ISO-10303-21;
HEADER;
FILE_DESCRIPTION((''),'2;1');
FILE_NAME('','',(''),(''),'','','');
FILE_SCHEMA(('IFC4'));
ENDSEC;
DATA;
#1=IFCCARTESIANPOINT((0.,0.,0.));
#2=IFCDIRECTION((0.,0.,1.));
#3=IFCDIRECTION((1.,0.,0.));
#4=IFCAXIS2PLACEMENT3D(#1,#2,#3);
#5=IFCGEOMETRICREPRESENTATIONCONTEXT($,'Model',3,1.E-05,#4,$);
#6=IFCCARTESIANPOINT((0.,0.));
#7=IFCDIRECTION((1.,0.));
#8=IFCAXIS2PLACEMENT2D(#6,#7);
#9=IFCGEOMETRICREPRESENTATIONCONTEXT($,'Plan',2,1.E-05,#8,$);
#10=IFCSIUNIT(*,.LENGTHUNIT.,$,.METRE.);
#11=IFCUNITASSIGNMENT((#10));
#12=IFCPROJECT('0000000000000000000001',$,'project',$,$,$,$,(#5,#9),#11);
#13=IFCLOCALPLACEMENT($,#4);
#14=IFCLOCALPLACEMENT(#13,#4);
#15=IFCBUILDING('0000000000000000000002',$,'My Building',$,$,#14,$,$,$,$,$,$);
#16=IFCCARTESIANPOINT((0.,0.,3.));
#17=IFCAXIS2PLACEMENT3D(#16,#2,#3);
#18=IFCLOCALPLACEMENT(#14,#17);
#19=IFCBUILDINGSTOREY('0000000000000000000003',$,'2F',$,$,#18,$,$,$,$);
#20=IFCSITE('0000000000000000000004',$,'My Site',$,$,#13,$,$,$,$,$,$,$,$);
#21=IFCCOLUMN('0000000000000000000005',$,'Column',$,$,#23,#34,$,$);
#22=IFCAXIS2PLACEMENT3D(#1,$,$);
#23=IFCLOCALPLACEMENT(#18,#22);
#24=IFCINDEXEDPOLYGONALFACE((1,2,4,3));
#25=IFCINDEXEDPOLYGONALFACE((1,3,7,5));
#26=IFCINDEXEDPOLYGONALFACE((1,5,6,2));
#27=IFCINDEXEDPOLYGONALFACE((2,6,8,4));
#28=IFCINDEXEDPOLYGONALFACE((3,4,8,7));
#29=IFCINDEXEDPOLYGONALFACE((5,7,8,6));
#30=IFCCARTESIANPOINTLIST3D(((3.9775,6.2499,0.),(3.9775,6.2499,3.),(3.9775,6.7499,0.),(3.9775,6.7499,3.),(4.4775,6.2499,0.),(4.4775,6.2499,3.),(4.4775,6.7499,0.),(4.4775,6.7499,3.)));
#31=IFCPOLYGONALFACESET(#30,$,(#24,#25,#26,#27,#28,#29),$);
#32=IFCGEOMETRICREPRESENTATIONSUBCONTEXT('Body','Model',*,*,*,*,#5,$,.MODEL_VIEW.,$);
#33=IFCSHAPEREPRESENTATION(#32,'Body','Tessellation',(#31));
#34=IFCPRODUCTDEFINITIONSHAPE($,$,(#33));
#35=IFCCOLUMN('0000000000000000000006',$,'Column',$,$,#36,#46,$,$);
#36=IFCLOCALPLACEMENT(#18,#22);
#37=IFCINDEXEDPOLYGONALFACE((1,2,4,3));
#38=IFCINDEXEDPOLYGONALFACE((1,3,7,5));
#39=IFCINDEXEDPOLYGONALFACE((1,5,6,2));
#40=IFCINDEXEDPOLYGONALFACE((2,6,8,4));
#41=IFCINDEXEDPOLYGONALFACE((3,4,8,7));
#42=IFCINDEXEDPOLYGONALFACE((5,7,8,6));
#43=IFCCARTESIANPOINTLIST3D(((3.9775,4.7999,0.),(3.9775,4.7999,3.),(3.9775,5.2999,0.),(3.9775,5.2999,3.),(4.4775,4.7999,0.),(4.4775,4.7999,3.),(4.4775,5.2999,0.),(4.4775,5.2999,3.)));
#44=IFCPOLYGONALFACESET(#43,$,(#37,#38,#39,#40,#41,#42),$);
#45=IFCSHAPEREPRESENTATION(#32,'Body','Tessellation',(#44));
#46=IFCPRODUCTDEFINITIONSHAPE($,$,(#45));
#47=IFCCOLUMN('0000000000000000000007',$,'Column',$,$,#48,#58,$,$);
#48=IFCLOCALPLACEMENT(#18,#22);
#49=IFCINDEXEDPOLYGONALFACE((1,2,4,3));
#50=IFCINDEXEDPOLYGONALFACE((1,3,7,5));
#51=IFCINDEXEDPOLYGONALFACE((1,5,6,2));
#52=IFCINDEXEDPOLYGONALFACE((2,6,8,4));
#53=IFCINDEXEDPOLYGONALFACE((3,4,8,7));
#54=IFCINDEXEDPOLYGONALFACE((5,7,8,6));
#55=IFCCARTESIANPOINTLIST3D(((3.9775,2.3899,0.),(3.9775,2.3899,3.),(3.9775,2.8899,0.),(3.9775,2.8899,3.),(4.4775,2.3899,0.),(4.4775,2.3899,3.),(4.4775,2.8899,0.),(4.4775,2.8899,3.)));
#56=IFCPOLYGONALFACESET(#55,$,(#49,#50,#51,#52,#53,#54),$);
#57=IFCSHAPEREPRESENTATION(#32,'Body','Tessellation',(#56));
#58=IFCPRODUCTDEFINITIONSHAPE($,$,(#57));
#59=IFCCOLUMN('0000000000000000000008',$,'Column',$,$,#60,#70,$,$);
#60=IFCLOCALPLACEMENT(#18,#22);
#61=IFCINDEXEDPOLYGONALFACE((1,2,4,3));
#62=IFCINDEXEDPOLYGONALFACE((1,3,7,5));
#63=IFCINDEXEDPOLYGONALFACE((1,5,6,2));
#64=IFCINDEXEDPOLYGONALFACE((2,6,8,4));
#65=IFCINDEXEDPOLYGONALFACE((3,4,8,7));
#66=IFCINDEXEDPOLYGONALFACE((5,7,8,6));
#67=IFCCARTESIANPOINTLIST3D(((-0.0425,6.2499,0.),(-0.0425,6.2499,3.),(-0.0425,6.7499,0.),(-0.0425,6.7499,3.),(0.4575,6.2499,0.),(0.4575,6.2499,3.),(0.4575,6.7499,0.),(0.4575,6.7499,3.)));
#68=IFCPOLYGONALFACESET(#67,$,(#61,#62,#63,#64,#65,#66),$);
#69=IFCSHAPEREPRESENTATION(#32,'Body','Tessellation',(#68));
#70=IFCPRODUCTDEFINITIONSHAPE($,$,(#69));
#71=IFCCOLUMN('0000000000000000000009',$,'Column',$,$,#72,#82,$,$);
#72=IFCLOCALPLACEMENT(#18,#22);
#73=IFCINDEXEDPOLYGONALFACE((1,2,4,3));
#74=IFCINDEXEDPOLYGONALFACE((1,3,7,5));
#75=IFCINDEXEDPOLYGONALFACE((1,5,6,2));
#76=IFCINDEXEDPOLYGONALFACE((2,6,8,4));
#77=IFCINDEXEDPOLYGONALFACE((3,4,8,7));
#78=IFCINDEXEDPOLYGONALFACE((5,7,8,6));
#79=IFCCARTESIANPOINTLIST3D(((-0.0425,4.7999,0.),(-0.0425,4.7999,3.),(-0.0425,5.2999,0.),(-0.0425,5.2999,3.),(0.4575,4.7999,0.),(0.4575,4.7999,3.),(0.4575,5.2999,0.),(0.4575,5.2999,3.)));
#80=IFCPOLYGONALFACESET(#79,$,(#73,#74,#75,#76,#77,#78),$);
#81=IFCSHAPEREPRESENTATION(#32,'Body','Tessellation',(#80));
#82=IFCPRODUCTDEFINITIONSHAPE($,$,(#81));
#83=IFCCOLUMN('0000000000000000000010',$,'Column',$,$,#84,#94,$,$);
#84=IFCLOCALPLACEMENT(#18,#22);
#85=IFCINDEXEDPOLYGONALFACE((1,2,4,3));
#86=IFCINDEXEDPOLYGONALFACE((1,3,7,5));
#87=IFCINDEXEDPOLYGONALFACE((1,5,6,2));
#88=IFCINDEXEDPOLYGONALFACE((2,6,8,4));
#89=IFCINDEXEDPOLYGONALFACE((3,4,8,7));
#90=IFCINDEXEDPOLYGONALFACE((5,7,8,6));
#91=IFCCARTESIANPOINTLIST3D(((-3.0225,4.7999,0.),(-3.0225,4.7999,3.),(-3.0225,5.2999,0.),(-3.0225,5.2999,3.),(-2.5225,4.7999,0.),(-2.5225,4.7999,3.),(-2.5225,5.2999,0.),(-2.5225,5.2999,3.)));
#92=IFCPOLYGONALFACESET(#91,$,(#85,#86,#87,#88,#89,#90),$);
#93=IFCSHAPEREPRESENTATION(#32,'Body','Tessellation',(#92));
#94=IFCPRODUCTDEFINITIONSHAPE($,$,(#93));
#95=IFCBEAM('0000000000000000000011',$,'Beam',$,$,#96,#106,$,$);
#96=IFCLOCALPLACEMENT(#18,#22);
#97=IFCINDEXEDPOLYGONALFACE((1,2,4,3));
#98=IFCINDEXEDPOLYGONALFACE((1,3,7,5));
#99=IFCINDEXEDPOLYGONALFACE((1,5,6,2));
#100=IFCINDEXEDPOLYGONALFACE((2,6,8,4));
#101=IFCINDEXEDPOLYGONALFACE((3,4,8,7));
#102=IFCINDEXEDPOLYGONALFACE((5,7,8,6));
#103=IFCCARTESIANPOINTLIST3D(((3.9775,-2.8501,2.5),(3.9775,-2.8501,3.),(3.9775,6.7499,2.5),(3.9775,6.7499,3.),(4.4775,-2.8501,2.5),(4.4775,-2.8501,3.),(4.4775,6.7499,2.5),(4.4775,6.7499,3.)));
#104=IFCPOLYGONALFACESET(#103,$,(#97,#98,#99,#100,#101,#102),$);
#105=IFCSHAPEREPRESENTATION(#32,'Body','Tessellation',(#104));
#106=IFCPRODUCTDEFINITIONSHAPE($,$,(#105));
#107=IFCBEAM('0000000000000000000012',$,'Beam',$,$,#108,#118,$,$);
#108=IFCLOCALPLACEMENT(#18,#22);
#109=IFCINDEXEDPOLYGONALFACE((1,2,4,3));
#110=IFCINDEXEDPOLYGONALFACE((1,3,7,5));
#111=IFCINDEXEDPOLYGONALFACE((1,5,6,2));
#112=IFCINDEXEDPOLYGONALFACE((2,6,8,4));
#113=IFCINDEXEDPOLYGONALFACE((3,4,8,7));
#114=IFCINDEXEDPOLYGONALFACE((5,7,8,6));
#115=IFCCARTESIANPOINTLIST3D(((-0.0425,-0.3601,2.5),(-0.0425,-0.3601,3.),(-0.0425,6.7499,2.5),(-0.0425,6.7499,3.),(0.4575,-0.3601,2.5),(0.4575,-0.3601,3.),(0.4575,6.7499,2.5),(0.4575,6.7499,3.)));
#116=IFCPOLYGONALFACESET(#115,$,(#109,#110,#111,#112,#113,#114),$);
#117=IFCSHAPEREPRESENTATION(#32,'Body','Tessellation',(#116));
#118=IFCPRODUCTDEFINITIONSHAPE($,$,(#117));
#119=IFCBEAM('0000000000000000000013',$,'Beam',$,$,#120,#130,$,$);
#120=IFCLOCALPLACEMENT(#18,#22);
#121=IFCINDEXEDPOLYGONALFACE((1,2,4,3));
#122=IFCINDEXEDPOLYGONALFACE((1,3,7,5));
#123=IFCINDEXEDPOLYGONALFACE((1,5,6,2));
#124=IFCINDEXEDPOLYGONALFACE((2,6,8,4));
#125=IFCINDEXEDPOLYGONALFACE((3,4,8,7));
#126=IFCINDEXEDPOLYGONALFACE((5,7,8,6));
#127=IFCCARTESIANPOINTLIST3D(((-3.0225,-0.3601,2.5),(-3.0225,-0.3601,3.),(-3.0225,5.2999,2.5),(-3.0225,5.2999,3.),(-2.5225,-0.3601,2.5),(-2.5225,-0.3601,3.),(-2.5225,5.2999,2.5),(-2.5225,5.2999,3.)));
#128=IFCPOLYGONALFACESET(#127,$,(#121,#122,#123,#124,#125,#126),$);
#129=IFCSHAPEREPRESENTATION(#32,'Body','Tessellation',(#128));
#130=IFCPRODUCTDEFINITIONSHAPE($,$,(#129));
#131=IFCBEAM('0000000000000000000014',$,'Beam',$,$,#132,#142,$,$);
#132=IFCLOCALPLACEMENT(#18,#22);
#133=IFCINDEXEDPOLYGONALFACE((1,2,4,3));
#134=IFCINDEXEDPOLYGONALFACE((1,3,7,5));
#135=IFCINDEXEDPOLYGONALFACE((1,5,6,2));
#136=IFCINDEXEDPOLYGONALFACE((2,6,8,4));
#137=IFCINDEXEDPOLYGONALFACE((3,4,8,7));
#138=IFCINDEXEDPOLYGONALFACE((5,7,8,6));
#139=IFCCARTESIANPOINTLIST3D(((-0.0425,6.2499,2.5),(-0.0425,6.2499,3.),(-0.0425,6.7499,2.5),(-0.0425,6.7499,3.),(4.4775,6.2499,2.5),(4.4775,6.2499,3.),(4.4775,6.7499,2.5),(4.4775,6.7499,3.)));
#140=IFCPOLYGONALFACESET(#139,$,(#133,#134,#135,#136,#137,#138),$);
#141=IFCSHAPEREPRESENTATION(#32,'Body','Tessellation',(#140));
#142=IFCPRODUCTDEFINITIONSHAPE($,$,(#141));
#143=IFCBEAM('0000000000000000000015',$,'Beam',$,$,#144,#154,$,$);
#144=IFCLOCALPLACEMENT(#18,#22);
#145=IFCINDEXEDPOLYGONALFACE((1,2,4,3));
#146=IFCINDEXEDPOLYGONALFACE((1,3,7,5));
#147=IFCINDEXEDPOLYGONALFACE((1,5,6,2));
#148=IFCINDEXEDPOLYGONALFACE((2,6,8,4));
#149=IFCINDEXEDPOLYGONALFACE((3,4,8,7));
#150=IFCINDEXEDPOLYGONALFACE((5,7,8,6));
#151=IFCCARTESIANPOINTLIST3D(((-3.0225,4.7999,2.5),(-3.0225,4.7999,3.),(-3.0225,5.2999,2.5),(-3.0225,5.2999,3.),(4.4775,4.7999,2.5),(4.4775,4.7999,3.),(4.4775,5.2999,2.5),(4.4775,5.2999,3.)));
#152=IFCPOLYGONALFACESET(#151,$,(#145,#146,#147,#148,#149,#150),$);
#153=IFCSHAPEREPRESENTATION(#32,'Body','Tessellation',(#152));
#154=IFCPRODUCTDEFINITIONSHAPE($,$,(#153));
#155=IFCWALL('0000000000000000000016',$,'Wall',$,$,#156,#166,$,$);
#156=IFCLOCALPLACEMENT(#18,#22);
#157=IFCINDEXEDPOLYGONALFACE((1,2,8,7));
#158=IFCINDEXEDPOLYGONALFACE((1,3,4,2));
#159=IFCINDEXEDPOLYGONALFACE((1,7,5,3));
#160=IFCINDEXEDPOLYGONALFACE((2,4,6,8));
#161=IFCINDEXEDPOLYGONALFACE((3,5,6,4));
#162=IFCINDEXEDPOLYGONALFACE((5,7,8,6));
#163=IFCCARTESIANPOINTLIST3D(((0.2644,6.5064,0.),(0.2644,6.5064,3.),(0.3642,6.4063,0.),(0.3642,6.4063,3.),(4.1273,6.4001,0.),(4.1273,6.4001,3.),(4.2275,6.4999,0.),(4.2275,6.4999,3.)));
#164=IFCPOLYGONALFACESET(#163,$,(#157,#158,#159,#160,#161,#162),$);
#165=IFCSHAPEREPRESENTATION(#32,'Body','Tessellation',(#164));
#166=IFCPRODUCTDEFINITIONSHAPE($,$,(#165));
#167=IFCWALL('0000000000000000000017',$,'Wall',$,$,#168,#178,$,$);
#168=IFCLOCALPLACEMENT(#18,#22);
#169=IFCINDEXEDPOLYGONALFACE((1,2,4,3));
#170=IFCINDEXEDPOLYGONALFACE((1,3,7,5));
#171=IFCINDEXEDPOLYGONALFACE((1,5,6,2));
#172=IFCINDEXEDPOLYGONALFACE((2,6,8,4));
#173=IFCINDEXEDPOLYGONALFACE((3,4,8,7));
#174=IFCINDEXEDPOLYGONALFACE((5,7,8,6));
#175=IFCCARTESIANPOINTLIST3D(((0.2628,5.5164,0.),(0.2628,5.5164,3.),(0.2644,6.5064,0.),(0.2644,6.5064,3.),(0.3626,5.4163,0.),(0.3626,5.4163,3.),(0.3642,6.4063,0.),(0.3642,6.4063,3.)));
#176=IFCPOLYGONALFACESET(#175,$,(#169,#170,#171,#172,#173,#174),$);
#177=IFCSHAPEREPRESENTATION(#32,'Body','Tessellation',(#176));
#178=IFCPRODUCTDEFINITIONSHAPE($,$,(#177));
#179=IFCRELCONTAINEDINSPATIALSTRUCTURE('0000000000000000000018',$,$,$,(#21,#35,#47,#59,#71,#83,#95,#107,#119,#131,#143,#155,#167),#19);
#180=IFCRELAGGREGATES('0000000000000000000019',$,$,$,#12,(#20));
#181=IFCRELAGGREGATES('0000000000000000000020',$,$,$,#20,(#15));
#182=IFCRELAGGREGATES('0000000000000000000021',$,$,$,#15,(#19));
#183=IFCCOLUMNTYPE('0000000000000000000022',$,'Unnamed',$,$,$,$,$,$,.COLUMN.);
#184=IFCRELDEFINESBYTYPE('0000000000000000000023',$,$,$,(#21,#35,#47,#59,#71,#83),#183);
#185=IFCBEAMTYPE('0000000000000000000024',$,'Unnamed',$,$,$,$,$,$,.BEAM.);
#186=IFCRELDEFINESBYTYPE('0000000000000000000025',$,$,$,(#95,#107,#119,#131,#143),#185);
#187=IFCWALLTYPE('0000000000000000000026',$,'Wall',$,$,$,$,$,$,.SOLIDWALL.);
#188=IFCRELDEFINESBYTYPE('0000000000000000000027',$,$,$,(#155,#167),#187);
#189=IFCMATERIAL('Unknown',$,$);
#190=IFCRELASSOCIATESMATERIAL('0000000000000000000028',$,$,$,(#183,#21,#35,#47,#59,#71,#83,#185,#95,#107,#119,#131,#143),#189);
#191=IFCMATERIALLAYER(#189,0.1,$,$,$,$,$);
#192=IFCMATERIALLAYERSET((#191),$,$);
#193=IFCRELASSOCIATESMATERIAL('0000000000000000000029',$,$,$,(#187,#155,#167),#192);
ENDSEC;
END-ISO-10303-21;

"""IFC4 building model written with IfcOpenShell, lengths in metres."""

from ifc_helpers import new_model, si_unit, frame, origin_with_axes, origin_2d_with_axis, place, context, subcontext, project, spatial, line, indexed_curve, rectangle, outline, extrude, material, layer, layer_set, layer_usage, material_profile, profile_set, profile_usage, type_object, element, save


model = new_model("IFC4")

# Units and contexts
model_context = context("Model", 3, precision=1e-05, world=origin_with_axes())
plan_context = context("Plan", 2, precision=1e-05, world=origin_2d_with_axis())
body_context_1 = subcontext(model_context, "Body", "Model", "MODEL_VIEW")
ifc_project = project(units=[si_unit("LENGTHUNIT", "METRE")], contexts=[model_context, plan_context])

# Site, building, storey
site_placement = place(None, origin_with_axes())
site = spatial("IfcSite", under=ifc_project, at=site_placement, Name="My Site")
building_placement = place(site_placement, origin_with_axes())
building = spatial("IfcBuilding", under=site, at=building_placement, Name="My Building")
storey_placement = place(building_placement, frame((0.0, 0.0, 3.0), z_axis=(0.0, 0.0, 1.0), x_axis=(1.0, 0.0, 0.0)))
storey = spatial("IfcBuildingStorey", under=building, at=storey_placement, Name="2F")

# Columns
ifc_material = material(Name="Unknown")
ifc_material_profile_1 = material_profile(ifc_material, rectangle(XDim=0.5, YDim=0.5))
ifc_profile_set_1 = profile_set([ifc_material_profile_1])
ifc_profile_usage_1 = profile_usage(ifc_profile_set_1, cardinal=5)
column_type = type_object("IfcColumnType", Name="Unnamed", PredefinedType="COLUMN", material=ifc_profile_set_1)
column_1_placement = place(storey_placement, frame((4.2275, 6.4999, 0.0), z_axis=(0.0, 0.0, 1.0), x_axis=(1.0, 0.0, 0.0)))
element("IfcColumn", 1, at=column_1_placement, inside=storey, type_object=column_type, material=ifc_profile_usage_1, Name="Column", context=body_context_1, shape_type="SweptSolid", body=[
    extrude(rectangle(XDim=0.5, YDim=0.5), origin_with_axes(), (0.0, 0.0, 1.0), 3.0),
])
ifc_profile_usage_2 = profile_usage(ifc_profile_set_1, cardinal=5)
column_2_placement = place(storey_placement, frame((4.2275, 5.0499, 0.0), z_axis=(0.0, 0.0, 1.0), x_axis=(1.0, 0.0, 0.0)))
element("IfcColumn", 2, at=column_2_placement, inside=storey, type_object=column_type, material=ifc_profile_usage_2, Name="Column", context=body_context_1, shape_type="SweptSolid", body=[
    extrude(rectangle(XDim=0.5, YDim=0.5), origin_with_axes(), (0.0, 0.0, 1.0), 3.0),
])
ifc_profile_usage_3 = profile_usage(ifc_profile_set_1, cardinal=5)
column_3_placement = place(storey_placement, frame((4.2275, 2.6399, 0.0), z_axis=(0.0, 0.0, 1.0), x_axis=(1.0, 0.0, 0.0)))
element("IfcColumn", 3, at=column_3_placement, inside=storey, type_object=column_type, material=ifc_profile_usage_3, Name="Column", context=body_context_1, shape_type="SweptSolid", body=[
    extrude(rectangle(XDim=0.5, YDim=0.5), origin_with_axes(), (0.0, 0.0, 1.0), 3.0),
])
ifc_profile_usage_4 = profile_usage(ifc_profile_set_1, cardinal=5)
column_4_placement = place(storey_placement, frame((0.2075, 6.4999, 0.0), z_axis=(0.0, 0.0, 1.0), x_axis=(1.0, 0.0, 0.0)))
element("IfcColumn", 4, at=column_4_placement, inside=storey, type_object=column_type, material=ifc_profile_usage_4, Name="Column", context=body_context_1, shape_type="SweptSolid", body=[
    extrude(rectangle(XDim=0.5, YDim=0.5), origin_with_axes(), (0.0, 0.0, 1.0), 3.0),
])
ifc_profile_usage_5 = profile_usage(ifc_profile_set_1, cardinal=5)
column_5_placement = place(storey_placement, frame((0.2075, 5.0499, 0.0), z_axis=(0.0, 0.0, 1.0), x_axis=(1.0, 0.0, 0.0)))
element("IfcColumn", 5, at=column_5_placement, inside=storey, type_object=column_type, material=ifc_profile_usage_5, Name="Column", context=body_context_1, shape_type="SweptSolid", body=[
    extrude(rectangle(XDim=0.5, YDim=0.5), origin_with_axes(), (0.0, 0.0, 1.0), 3.0),
])
ifc_profile_usage_6 = profile_usage(ifc_profile_set_1, cardinal=5)
column_6_placement = place(storey_placement, frame((-2.7725, 5.0499, 0.0), z_axis=(0.0, 0.0, 1.0), x_axis=(1.0, 0.0, 0.0)))
element("IfcColumn", 6, at=column_6_placement, inside=storey, type_object=column_type, material=ifc_profile_usage_6, Name="Column", context=body_context_1, shape_type="SweptSolid", body=[
    extrude(rectangle(XDim=0.5, YDim=0.5), origin_with_axes(), (0.0, 0.0, 1.0), 3.0),
])

# Beams
ifc_material_profile_2 = material_profile(ifc_material, rectangle(XDim=0.5, YDim=0.5))
ifc_profile_set_2 = profile_set([ifc_material_profile_2])
ifc_profile_usage_7 = profile_usage(ifc_profile_set_2, cardinal=7)
beam_type = type_object("IfcBeamType", Name="Unnamed", PredefinedType="BEAM", material=ifc_profile_set_2)
beam_1_placement = place(storey_placement, frame((4.4775, 6.7499, 3.0), z_axis=(0.0, -1.0, 0.0), x_axis=(1.0, 0.0, 0.0)))
element("IfcBeam", 7, at=beam_1_placement, inside=storey, type_object=beam_type, material=ifc_profile_usage_7, Name="Beam", context=body_context_1, shape_type="SweptSolid", body=[
    extrude(rectangle(XDim=0.5, YDim=0.5), frame((-0.25, -0.25, 0.0), z_axis=(0.0, 0.0, 1.0), x_axis=(1.0, 0.0, 0.0)), (0.0, 0.0, 1.0), 9.6),
])
ifc_profile_usage_8 = profile_usage(ifc_profile_set_2, cardinal=7)
beam_2_placement = place(storey_placement, frame((0.4575, 6.7499, 3.0), z_axis=(0.0, -1.0, 0.0), x_axis=(1.0, 0.0, 0.0)))
element("IfcBeam", 8, at=beam_2_placement, inside=storey, type_object=beam_type, material=ifc_profile_usage_8, Name="Beam", context=body_context_1, shape_type="SweptSolid", body=[
    extrude(rectangle(XDim=0.5, YDim=0.5), frame((-0.25, -0.25, 0.0), z_axis=(0.0, 0.0, 1.0), x_axis=(1.0, 0.0, 0.0)), (0.0, 0.0, 1.0), 7.11),
])
ifc_profile_usage_9 = profile_usage(ifc_profile_set_2, cardinal=7)
beam_3_placement = place(storey_placement, frame((-2.5225, 5.2999, 3.0), z_axis=(0.0, -1.0, 0.0), x_axis=(1.0, 0.0, 0.0)))
element("IfcBeam", 9, at=beam_3_placement, inside=storey, type_object=beam_type, material=ifc_profile_usage_9, Name="Beam", context=body_context_1, shape_type="SweptSolid", body=[
    extrude(rectangle(XDim=0.5, YDim=0.5), frame((-0.25, -0.25, 0.0), z_axis=(0.0, 0.0, 1.0), x_axis=(1.0, 0.0, 0.0)), (0.0, 0.0, 1.0), 5.66),
])
ifc_profile_usage_10 = profile_usage(ifc_profile_set_2, cardinal=7)
beam_4_placement = place(storey_placement, frame((4.4775, 6.2499, 3.0), z_axis=(-1.0, 0.0, 0.0), x_axis=(0.0, -1.0, 0.0)))
element("IfcBeam", 10, at=beam_4_placement, inside=storey, type_object=beam_type, material=ifc_profile_usage_10, Name="Beam", context=body_context_1, shape_type="SweptSolid", body=[
    extrude(rectangle(XDim=0.5, YDim=0.5), frame((-0.25, -0.25, 0.0), z_axis=(0.0, 0.0, 1.0), x_axis=(1.0, 0.0, 0.0)), (0.0, 0.0, 1.0), 4.52),
])
ifc_profile_usage_11 = profile_usage(ifc_profile_set_2, cardinal=7)
beam_5_placement = place(storey_placement, frame((4.4775, 4.7999, 3.0), z_axis=(-1.0, 0.0, 0.0), x_axis=(0.0, -1.0, 0.0)))
element("IfcBeam", 11, at=beam_5_placement, inside=storey, type_object=beam_type, material=ifc_profile_usage_11, Name="Beam", context=body_context_1, shape_type="SweptSolid", body=[
    extrude(rectangle(XDim=0.5, YDim=0.5), frame((-0.25, -0.25, 0.0), z_axis=(0.0, 0.0, 1.0), x_axis=(1.0, 0.0, 0.0)), (0.0, 0.0, 1.0), 7.5),
])

# Walls
ifc_layer = layer(ifc_material, 0.1)
ifc_layer_set = layer_set([ifc_layer])
ifc_layer_usage_1 = layer_usage(ifc_layer_set, "AXIS2", "POSITIVE", 0.0)
wall_type = type_object("IfcWallType", Name="Wall", PredefinedType="SOLIDWALL", material=ifc_layer_set)
wall_1_placement = place(storey_placement, frame((4.2275, 6.4999, 0.0), z_axis=(0.0, 0.0, 1.0), x_axis=(-0.999999, 0.001639, 0.0)))
element("IfcWall", 12, at=wall_1_placement, inside=storey, type_object=wall_type, material=ifc_layer_usage_1, Name="Wall", context=body_context_1, shape_type="SweptSolid", body=[
    extrude(outline(indexed_curve([(0.0, 0.0), (0.1, 0.1), (3.8631, 0.1), (3.9631, 0.0)], segments=[line(1, 2, 3, 4, 1)])), origin_with_axes(), (0.0, 0.0, 1.0), 3.0),
])
ifc_layer_usage_2 = layer_usage(ifc_layer_set, "AXIS2", "POSITIVE", 0.0)
wall_2_placement = place(storey_placement, frame((0.2644, 6.5064, 0.0), z_axis=(0.0, 0.0, 1.0), x_axis=(-0.001639, -0.999999, 0.0)))
element("IfcWall", 13, at=wall_2_placement, inside=storey, type_object=wall_type, material=ifc_layer_usage_2, Name="Wall", context=body_context_1, shape_type="SweptSolid", body=[
    extrude(outline(indexed_curve([(0.0, 0.0), (0.1, 0.1), (1.09, 0.1), (0.99, 0.0)], segments=[line(1, 2, 3, 4, 1)])), origin_with_axes(), (0.0, 0.0, 1.0), 3.0),
])

save(model, "model.ifc")
